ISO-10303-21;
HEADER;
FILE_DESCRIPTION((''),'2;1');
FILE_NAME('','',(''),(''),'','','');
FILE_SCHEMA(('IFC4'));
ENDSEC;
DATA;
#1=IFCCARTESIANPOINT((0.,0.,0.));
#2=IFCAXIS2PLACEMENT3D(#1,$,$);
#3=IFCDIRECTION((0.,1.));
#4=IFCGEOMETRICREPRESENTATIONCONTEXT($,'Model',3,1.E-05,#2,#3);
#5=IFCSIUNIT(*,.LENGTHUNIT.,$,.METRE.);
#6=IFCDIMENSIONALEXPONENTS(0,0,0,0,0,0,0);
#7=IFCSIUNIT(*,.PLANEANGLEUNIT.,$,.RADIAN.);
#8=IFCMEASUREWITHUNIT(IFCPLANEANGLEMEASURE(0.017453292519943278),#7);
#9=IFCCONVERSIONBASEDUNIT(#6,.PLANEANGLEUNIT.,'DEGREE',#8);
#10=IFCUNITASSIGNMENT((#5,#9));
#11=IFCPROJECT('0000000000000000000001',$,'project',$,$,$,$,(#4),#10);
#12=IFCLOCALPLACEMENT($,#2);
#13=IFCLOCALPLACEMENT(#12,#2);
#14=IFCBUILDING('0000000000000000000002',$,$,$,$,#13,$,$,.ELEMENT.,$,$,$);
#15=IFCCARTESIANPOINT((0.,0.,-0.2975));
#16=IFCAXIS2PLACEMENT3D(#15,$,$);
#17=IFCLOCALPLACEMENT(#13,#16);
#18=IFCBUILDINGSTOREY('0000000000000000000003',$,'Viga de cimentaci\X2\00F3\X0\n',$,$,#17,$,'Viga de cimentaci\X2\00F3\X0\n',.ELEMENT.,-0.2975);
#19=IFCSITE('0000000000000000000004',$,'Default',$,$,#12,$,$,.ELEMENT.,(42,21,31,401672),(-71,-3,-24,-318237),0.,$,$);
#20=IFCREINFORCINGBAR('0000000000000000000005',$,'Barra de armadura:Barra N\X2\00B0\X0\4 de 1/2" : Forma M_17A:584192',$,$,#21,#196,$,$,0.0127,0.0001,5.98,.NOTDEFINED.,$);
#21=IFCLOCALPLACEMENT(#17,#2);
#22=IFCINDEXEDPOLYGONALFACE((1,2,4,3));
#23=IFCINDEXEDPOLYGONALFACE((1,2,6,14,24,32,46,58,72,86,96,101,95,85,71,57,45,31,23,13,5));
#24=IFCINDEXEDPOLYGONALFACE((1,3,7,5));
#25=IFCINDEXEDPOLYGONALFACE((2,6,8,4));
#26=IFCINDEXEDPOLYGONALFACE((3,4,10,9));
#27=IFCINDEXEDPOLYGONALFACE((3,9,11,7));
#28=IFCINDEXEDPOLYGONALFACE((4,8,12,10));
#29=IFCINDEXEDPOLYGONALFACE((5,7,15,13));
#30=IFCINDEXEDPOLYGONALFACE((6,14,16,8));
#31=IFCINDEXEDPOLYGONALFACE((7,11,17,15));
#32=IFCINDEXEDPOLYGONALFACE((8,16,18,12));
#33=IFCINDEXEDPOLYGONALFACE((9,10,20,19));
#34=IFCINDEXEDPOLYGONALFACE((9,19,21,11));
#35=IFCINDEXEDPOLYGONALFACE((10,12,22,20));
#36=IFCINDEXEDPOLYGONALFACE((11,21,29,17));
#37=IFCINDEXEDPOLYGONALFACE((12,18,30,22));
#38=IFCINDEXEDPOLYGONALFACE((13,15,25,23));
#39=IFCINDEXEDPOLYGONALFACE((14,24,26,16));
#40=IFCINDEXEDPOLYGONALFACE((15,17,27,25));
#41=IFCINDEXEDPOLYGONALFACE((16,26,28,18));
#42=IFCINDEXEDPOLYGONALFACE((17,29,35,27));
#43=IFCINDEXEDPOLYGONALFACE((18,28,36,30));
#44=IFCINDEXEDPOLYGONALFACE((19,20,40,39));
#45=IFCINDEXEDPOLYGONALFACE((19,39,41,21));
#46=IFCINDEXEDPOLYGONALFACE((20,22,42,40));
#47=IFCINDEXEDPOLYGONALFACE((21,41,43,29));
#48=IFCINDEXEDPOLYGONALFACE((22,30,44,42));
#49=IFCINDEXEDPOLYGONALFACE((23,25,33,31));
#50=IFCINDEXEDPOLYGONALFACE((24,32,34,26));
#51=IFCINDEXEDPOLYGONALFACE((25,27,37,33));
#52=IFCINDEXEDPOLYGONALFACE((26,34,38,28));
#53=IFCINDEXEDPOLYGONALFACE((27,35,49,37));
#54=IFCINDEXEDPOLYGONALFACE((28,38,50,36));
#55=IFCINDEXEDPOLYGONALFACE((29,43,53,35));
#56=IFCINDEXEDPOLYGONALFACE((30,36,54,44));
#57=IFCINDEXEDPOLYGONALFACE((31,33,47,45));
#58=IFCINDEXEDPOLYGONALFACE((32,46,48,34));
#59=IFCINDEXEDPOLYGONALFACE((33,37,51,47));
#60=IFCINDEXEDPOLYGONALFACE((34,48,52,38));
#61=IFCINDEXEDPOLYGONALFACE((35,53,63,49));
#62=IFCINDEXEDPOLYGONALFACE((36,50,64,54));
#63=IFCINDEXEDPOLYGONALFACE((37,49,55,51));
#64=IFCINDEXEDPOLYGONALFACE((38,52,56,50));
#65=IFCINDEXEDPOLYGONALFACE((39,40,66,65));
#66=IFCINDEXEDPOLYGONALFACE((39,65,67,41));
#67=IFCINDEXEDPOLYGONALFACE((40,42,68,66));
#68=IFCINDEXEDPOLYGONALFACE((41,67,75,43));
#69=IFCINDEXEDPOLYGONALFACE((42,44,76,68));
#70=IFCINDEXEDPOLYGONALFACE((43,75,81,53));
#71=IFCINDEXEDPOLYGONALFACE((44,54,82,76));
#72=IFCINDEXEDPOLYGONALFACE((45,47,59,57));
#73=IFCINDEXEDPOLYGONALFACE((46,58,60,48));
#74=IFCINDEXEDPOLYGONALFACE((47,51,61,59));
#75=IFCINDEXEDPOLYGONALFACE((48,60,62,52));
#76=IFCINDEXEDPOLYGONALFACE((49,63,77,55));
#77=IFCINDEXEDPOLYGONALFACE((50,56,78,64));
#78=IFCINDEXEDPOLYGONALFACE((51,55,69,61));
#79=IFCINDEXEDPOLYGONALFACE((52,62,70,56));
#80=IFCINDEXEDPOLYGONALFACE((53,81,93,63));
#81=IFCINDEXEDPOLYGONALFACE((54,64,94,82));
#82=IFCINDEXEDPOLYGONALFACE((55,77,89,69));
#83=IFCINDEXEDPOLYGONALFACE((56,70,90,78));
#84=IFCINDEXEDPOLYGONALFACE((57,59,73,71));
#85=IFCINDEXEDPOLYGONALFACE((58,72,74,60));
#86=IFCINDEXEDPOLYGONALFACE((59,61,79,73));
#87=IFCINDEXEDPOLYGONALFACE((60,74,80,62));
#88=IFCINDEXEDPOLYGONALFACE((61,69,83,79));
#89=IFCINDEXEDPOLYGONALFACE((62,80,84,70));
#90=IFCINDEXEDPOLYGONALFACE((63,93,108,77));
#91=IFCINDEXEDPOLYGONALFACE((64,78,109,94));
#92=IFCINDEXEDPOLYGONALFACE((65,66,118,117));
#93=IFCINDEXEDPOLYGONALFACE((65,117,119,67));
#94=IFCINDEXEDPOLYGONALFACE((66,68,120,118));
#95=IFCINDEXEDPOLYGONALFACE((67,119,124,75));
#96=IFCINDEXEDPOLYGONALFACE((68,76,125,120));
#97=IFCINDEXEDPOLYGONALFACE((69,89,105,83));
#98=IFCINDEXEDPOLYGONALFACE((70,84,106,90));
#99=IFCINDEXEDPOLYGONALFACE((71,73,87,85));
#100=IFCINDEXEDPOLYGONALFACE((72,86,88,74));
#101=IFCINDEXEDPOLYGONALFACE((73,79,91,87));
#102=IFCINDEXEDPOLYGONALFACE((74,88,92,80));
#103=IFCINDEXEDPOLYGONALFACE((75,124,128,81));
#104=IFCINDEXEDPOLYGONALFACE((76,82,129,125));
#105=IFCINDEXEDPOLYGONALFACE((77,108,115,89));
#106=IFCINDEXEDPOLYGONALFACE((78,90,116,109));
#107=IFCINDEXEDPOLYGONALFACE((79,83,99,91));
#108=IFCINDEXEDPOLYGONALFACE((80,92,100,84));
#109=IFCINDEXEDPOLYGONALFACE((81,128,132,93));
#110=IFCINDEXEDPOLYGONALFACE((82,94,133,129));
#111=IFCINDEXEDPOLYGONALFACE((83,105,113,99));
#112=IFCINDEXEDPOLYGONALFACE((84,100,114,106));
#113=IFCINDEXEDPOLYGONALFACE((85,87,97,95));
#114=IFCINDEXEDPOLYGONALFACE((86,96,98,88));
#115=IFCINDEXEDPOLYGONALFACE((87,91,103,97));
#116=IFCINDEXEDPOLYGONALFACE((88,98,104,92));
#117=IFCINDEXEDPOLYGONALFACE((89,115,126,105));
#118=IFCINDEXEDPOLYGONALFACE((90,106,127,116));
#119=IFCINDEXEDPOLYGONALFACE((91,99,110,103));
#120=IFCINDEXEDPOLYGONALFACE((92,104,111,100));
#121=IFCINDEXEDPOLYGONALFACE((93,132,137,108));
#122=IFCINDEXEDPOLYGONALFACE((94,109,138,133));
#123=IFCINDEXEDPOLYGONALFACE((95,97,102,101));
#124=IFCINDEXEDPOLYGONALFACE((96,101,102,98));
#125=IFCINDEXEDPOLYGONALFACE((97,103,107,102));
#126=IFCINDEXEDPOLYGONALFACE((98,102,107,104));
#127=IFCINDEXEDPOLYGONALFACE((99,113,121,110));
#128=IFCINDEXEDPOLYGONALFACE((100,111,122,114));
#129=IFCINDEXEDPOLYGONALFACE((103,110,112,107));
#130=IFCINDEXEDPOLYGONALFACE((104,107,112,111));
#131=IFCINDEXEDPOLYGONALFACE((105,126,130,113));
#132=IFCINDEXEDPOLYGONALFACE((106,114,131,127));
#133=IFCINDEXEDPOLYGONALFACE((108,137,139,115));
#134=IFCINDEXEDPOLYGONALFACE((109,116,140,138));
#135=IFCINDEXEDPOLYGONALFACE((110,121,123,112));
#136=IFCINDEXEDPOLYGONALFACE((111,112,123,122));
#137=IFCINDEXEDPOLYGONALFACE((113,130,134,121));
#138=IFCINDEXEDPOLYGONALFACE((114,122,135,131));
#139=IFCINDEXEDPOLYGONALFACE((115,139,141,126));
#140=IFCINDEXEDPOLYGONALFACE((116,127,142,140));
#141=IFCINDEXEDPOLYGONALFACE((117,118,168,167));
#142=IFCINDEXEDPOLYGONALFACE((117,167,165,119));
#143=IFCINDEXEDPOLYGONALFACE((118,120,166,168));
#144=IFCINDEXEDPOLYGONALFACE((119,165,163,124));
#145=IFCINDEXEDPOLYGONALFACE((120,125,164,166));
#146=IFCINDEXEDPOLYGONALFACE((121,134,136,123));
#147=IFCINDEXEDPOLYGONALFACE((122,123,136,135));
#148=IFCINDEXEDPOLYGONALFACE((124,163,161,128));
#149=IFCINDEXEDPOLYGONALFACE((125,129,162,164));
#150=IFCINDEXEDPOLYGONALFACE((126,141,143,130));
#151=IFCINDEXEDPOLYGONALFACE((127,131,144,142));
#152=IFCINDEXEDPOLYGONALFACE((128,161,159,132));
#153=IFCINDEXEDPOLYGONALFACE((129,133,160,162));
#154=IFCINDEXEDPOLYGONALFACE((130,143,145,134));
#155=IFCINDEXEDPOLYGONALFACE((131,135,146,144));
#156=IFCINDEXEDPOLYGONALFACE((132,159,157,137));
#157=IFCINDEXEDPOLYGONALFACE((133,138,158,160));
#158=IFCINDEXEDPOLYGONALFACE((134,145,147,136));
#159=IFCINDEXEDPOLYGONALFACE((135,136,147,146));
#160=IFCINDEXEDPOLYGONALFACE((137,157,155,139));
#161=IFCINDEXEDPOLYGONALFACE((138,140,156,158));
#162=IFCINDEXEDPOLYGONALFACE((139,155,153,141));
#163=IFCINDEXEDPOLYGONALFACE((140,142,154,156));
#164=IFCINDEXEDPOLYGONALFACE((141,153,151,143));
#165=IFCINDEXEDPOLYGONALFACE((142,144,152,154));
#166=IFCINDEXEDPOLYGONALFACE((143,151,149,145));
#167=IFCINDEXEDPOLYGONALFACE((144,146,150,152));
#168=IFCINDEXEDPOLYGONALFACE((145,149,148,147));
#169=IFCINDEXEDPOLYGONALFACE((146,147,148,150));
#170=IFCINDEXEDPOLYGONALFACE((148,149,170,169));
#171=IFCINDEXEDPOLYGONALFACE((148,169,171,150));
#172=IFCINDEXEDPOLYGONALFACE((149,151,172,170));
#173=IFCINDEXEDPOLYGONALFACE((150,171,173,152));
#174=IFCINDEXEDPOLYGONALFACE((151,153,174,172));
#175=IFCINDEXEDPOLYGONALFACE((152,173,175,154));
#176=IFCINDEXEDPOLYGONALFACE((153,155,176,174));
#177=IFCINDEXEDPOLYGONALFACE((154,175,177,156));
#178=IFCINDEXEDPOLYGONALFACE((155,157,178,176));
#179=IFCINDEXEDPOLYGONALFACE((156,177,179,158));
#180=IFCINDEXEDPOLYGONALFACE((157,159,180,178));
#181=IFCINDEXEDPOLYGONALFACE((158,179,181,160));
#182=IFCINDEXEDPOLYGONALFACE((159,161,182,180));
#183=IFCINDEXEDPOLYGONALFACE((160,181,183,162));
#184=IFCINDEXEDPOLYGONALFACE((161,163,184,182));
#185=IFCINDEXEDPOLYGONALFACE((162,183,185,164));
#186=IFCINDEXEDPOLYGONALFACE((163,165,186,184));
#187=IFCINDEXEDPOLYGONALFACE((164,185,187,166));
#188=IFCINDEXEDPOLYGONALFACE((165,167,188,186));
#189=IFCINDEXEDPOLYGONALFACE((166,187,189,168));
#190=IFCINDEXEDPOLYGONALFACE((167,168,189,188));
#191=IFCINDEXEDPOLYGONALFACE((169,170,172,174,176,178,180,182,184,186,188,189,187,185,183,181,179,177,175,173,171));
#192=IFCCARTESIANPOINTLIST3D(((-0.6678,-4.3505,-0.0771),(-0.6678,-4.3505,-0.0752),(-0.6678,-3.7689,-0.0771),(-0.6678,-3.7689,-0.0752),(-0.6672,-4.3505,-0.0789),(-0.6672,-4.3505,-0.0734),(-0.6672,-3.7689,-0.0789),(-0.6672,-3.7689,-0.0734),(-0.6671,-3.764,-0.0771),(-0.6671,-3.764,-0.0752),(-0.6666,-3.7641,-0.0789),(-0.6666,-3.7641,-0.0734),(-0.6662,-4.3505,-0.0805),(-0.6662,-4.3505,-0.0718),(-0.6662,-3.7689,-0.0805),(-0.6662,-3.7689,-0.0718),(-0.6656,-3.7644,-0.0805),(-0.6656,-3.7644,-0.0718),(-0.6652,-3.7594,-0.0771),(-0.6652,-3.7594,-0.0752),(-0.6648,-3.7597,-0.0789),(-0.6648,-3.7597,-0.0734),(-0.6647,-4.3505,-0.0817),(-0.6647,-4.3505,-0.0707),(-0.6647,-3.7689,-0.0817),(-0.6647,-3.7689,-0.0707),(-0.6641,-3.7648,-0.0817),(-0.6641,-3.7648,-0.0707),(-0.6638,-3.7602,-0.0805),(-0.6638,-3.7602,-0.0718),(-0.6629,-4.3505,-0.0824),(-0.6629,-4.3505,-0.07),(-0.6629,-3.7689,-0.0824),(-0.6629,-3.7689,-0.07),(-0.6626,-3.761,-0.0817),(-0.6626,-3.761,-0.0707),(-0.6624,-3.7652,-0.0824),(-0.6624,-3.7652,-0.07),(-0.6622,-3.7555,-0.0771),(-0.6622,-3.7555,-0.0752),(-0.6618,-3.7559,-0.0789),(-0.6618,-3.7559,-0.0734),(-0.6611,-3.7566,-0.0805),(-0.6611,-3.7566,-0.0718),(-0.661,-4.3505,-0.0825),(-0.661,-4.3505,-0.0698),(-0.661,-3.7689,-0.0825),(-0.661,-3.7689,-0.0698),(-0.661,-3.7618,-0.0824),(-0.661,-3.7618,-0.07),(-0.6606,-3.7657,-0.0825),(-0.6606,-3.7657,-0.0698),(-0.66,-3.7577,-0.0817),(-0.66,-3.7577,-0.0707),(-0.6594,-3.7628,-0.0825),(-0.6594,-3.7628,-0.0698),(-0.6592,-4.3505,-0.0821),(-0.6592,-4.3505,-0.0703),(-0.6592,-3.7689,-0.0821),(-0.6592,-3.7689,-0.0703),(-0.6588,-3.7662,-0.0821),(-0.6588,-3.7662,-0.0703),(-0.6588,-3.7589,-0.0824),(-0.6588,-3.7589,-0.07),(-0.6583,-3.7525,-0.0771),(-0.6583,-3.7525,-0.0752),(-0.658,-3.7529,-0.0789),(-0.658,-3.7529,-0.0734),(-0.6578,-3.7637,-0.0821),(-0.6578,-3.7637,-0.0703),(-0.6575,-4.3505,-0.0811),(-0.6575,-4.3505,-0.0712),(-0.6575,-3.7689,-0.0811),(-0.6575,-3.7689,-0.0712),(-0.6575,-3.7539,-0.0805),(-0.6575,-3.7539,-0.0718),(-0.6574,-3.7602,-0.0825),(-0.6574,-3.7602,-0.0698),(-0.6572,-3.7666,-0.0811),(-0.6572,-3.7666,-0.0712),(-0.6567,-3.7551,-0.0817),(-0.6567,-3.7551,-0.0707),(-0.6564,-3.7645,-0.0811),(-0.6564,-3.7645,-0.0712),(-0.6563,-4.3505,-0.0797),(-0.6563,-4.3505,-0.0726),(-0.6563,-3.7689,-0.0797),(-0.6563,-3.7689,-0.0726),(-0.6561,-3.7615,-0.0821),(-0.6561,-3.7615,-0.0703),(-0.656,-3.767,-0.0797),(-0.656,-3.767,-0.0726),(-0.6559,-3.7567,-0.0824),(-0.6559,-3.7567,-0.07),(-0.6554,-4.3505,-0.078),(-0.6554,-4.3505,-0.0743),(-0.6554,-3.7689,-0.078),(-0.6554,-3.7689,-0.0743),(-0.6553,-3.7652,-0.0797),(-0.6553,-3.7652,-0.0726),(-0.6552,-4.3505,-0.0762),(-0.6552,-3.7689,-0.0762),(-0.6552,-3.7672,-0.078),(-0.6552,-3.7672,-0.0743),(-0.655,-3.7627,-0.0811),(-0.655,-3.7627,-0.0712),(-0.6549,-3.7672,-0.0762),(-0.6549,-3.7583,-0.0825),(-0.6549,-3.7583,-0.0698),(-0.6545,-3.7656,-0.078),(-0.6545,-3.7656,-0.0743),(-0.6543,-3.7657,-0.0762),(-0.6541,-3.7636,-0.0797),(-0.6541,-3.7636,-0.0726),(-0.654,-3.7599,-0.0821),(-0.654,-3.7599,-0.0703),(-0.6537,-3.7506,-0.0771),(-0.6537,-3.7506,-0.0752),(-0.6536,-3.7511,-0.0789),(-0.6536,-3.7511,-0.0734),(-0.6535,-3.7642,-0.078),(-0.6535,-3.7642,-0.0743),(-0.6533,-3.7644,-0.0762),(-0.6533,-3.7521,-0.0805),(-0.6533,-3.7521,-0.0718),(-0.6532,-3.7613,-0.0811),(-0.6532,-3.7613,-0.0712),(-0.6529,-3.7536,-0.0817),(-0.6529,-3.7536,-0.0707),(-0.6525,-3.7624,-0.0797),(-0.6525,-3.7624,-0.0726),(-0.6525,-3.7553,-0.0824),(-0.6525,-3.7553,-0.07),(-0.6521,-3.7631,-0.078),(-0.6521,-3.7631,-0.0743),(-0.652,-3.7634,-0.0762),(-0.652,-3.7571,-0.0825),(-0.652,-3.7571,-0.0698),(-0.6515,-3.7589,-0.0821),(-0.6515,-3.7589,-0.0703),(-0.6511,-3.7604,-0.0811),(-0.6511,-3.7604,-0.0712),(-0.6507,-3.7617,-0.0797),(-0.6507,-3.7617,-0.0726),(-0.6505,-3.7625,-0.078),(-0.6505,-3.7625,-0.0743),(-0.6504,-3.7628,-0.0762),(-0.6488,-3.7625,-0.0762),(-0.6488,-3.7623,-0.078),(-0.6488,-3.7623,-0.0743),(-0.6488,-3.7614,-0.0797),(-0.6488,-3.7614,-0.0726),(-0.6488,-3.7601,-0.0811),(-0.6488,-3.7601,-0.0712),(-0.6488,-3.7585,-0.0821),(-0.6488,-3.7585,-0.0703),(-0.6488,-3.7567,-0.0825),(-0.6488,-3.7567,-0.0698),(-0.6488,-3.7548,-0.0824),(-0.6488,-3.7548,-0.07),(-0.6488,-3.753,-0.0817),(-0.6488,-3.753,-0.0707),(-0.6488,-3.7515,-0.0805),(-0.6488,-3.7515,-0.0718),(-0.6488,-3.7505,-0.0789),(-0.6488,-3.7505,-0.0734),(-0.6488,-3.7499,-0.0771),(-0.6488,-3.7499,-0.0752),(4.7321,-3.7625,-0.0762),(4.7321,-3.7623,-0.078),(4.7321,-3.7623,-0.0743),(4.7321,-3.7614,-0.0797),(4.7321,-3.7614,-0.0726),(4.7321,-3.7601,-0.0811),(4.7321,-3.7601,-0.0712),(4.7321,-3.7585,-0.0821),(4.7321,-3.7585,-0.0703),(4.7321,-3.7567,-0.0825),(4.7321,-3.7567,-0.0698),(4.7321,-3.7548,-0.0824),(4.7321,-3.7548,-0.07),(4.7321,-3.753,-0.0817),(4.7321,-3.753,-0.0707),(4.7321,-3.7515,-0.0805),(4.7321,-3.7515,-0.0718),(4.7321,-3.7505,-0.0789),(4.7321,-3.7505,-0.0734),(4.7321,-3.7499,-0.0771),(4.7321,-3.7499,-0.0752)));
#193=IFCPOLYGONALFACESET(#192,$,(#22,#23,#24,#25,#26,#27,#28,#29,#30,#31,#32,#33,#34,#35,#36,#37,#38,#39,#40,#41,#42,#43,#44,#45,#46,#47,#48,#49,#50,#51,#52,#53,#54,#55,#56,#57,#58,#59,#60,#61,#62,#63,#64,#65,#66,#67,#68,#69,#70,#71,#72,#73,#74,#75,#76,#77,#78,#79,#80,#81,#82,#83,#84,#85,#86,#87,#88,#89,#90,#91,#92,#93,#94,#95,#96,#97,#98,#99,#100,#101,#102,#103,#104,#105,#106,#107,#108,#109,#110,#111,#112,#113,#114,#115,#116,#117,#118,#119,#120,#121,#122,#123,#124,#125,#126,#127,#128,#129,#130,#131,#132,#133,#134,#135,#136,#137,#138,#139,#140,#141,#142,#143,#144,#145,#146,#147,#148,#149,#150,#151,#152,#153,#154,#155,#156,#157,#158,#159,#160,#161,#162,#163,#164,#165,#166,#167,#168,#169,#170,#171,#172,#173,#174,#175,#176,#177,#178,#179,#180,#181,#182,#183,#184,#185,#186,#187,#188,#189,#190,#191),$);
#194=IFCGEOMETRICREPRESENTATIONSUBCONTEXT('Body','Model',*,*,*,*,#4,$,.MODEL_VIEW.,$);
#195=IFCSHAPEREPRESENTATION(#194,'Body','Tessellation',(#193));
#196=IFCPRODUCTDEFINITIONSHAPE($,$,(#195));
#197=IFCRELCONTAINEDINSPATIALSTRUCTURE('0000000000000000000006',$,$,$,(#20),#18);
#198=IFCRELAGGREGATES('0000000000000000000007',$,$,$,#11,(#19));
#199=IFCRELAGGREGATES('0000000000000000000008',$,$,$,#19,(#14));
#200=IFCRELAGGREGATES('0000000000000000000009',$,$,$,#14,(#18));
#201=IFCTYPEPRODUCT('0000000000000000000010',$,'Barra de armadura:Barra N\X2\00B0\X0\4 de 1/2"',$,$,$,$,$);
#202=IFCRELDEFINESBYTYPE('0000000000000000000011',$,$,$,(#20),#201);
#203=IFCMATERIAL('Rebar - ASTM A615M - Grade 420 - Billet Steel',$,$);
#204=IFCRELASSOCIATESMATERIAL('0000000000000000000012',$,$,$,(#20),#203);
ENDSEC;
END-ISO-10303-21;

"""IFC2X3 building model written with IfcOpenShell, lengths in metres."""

from ifc_helpers import new_model, entity, si_unit, converted_unit, direction, frame, origin, place, context, subcontext, project, spatial, material, type_object, element, save


model = new_model("IFC2X3")

# Units and contexts
model_context = context("Model", 3, precision=1e-05, world=origin(), true_north=direction((0.0, 1.0)))
body_context = subcontext(model_context, "Body", "Model", "MODEL_VIEW")
ifc_project = project(units=[si_unit("LENGTHUNIT", "METRE"), converted_unit("PLANEANGLEUNIT", "DEGREE", entity("IfcPlaneAngleMeasure", 0.017453292519943278), si_unit("PLANEANGLEUNIT", "RADIAN"), dimensions=[0, 0, 0, 0, 0, 0, 0])], contexts=[model_context])

# Site, building, storey
site_placement = place(None, origin())
site = spatial("IfcSite", under=ifc_project, at=site_placement, Name="Default", CompositionType="ELEMENT", RefLatitude=(42, 21, 31, 401672), RefLongitude=(-71, -3, -24, -318237), RefElevation=0.0)
building_placement = place(site_placement, origin())
building = spatial("IfcBuilding", under=site, at=building_placement, CompositionType="ELEMENT")
storey_placement = place(building_placement, frame((0.0, 0.0, -0.2975)))
storey = spatial("IfcBuildingStorey", under=building, at=storey_placement, Name="Viga de cimentación", LongName="Viga de cimentación", CompositionType="ELEMENT", Elevation=-0.2975)

# Reinforcing bar
ifc_material = material(Name="Rebar - ASTM A615M - Grade 420 - Billet Steel")
type_product_1 = type_object("IfcTypeProduct", Name="Barra de armadura:Barra N°4 de 1/2\"")
reinforcing_bar_1_placement = place(storey_placement, origin())
element("IfcReinforcingBar", 1, at=reinforcing_bar_1_placement, inside=storey, type_object=type_product_1, material=ifc_material, Name="Barra de armadura:Barra N°4 de 1/2\" : Forma M_17A:584192", BarLength=5.98, BarRole="NOTDEFINED", CrossSectionArea=0.0001, NominalDiameter=0.0127, context=body_context, shape_type="AdvancedSweptSolid", body=[
    entity("IfcSweptDiskSolid", entity("IfcCompositeCurve", [entity("IfcCompositeCurveSegment", "CONTINUOUS", True, entity("IfcPolyline", [entity("IfcCartesianPoint", [-0.6615, -4.3505, -0.0762]), entity("IfcCartesianPoint", [-0.6615, -3.7689, -0.0762])])), entity("IfcCompositeCurveSegment", "CONTINUOUS", True, entity("IfcTrimmedCurve", entity("IfcCircle", entity("IfcAxis2Placement3D", entity("IfcCartesianPoint", [-0.6488, -3.7689, -0.0762]), entity("IfcDirection", [0.0, 0.0, -1.0]), entity("IfcDirection", [0.0, 1.0, 0.0])), 0.0127), [entity("IfcParameterValue", 270.0)], [entity("IfcParameterValue", 360.0)], True, "PARAMETER")), entity("IfcCompositeCurveSegment", "CONTINUOUS", True, entity("IfcPolyline", [entity("IfcCartesianPoint", [-0.6488, -3.7562, -0.0762]), entity("IfcCartesianPoint", [4.7321, -3.7562, -0.0762])]))], False), 0.0063, None, 0.0, 92.0),
])

save(model, "model.ifc")
